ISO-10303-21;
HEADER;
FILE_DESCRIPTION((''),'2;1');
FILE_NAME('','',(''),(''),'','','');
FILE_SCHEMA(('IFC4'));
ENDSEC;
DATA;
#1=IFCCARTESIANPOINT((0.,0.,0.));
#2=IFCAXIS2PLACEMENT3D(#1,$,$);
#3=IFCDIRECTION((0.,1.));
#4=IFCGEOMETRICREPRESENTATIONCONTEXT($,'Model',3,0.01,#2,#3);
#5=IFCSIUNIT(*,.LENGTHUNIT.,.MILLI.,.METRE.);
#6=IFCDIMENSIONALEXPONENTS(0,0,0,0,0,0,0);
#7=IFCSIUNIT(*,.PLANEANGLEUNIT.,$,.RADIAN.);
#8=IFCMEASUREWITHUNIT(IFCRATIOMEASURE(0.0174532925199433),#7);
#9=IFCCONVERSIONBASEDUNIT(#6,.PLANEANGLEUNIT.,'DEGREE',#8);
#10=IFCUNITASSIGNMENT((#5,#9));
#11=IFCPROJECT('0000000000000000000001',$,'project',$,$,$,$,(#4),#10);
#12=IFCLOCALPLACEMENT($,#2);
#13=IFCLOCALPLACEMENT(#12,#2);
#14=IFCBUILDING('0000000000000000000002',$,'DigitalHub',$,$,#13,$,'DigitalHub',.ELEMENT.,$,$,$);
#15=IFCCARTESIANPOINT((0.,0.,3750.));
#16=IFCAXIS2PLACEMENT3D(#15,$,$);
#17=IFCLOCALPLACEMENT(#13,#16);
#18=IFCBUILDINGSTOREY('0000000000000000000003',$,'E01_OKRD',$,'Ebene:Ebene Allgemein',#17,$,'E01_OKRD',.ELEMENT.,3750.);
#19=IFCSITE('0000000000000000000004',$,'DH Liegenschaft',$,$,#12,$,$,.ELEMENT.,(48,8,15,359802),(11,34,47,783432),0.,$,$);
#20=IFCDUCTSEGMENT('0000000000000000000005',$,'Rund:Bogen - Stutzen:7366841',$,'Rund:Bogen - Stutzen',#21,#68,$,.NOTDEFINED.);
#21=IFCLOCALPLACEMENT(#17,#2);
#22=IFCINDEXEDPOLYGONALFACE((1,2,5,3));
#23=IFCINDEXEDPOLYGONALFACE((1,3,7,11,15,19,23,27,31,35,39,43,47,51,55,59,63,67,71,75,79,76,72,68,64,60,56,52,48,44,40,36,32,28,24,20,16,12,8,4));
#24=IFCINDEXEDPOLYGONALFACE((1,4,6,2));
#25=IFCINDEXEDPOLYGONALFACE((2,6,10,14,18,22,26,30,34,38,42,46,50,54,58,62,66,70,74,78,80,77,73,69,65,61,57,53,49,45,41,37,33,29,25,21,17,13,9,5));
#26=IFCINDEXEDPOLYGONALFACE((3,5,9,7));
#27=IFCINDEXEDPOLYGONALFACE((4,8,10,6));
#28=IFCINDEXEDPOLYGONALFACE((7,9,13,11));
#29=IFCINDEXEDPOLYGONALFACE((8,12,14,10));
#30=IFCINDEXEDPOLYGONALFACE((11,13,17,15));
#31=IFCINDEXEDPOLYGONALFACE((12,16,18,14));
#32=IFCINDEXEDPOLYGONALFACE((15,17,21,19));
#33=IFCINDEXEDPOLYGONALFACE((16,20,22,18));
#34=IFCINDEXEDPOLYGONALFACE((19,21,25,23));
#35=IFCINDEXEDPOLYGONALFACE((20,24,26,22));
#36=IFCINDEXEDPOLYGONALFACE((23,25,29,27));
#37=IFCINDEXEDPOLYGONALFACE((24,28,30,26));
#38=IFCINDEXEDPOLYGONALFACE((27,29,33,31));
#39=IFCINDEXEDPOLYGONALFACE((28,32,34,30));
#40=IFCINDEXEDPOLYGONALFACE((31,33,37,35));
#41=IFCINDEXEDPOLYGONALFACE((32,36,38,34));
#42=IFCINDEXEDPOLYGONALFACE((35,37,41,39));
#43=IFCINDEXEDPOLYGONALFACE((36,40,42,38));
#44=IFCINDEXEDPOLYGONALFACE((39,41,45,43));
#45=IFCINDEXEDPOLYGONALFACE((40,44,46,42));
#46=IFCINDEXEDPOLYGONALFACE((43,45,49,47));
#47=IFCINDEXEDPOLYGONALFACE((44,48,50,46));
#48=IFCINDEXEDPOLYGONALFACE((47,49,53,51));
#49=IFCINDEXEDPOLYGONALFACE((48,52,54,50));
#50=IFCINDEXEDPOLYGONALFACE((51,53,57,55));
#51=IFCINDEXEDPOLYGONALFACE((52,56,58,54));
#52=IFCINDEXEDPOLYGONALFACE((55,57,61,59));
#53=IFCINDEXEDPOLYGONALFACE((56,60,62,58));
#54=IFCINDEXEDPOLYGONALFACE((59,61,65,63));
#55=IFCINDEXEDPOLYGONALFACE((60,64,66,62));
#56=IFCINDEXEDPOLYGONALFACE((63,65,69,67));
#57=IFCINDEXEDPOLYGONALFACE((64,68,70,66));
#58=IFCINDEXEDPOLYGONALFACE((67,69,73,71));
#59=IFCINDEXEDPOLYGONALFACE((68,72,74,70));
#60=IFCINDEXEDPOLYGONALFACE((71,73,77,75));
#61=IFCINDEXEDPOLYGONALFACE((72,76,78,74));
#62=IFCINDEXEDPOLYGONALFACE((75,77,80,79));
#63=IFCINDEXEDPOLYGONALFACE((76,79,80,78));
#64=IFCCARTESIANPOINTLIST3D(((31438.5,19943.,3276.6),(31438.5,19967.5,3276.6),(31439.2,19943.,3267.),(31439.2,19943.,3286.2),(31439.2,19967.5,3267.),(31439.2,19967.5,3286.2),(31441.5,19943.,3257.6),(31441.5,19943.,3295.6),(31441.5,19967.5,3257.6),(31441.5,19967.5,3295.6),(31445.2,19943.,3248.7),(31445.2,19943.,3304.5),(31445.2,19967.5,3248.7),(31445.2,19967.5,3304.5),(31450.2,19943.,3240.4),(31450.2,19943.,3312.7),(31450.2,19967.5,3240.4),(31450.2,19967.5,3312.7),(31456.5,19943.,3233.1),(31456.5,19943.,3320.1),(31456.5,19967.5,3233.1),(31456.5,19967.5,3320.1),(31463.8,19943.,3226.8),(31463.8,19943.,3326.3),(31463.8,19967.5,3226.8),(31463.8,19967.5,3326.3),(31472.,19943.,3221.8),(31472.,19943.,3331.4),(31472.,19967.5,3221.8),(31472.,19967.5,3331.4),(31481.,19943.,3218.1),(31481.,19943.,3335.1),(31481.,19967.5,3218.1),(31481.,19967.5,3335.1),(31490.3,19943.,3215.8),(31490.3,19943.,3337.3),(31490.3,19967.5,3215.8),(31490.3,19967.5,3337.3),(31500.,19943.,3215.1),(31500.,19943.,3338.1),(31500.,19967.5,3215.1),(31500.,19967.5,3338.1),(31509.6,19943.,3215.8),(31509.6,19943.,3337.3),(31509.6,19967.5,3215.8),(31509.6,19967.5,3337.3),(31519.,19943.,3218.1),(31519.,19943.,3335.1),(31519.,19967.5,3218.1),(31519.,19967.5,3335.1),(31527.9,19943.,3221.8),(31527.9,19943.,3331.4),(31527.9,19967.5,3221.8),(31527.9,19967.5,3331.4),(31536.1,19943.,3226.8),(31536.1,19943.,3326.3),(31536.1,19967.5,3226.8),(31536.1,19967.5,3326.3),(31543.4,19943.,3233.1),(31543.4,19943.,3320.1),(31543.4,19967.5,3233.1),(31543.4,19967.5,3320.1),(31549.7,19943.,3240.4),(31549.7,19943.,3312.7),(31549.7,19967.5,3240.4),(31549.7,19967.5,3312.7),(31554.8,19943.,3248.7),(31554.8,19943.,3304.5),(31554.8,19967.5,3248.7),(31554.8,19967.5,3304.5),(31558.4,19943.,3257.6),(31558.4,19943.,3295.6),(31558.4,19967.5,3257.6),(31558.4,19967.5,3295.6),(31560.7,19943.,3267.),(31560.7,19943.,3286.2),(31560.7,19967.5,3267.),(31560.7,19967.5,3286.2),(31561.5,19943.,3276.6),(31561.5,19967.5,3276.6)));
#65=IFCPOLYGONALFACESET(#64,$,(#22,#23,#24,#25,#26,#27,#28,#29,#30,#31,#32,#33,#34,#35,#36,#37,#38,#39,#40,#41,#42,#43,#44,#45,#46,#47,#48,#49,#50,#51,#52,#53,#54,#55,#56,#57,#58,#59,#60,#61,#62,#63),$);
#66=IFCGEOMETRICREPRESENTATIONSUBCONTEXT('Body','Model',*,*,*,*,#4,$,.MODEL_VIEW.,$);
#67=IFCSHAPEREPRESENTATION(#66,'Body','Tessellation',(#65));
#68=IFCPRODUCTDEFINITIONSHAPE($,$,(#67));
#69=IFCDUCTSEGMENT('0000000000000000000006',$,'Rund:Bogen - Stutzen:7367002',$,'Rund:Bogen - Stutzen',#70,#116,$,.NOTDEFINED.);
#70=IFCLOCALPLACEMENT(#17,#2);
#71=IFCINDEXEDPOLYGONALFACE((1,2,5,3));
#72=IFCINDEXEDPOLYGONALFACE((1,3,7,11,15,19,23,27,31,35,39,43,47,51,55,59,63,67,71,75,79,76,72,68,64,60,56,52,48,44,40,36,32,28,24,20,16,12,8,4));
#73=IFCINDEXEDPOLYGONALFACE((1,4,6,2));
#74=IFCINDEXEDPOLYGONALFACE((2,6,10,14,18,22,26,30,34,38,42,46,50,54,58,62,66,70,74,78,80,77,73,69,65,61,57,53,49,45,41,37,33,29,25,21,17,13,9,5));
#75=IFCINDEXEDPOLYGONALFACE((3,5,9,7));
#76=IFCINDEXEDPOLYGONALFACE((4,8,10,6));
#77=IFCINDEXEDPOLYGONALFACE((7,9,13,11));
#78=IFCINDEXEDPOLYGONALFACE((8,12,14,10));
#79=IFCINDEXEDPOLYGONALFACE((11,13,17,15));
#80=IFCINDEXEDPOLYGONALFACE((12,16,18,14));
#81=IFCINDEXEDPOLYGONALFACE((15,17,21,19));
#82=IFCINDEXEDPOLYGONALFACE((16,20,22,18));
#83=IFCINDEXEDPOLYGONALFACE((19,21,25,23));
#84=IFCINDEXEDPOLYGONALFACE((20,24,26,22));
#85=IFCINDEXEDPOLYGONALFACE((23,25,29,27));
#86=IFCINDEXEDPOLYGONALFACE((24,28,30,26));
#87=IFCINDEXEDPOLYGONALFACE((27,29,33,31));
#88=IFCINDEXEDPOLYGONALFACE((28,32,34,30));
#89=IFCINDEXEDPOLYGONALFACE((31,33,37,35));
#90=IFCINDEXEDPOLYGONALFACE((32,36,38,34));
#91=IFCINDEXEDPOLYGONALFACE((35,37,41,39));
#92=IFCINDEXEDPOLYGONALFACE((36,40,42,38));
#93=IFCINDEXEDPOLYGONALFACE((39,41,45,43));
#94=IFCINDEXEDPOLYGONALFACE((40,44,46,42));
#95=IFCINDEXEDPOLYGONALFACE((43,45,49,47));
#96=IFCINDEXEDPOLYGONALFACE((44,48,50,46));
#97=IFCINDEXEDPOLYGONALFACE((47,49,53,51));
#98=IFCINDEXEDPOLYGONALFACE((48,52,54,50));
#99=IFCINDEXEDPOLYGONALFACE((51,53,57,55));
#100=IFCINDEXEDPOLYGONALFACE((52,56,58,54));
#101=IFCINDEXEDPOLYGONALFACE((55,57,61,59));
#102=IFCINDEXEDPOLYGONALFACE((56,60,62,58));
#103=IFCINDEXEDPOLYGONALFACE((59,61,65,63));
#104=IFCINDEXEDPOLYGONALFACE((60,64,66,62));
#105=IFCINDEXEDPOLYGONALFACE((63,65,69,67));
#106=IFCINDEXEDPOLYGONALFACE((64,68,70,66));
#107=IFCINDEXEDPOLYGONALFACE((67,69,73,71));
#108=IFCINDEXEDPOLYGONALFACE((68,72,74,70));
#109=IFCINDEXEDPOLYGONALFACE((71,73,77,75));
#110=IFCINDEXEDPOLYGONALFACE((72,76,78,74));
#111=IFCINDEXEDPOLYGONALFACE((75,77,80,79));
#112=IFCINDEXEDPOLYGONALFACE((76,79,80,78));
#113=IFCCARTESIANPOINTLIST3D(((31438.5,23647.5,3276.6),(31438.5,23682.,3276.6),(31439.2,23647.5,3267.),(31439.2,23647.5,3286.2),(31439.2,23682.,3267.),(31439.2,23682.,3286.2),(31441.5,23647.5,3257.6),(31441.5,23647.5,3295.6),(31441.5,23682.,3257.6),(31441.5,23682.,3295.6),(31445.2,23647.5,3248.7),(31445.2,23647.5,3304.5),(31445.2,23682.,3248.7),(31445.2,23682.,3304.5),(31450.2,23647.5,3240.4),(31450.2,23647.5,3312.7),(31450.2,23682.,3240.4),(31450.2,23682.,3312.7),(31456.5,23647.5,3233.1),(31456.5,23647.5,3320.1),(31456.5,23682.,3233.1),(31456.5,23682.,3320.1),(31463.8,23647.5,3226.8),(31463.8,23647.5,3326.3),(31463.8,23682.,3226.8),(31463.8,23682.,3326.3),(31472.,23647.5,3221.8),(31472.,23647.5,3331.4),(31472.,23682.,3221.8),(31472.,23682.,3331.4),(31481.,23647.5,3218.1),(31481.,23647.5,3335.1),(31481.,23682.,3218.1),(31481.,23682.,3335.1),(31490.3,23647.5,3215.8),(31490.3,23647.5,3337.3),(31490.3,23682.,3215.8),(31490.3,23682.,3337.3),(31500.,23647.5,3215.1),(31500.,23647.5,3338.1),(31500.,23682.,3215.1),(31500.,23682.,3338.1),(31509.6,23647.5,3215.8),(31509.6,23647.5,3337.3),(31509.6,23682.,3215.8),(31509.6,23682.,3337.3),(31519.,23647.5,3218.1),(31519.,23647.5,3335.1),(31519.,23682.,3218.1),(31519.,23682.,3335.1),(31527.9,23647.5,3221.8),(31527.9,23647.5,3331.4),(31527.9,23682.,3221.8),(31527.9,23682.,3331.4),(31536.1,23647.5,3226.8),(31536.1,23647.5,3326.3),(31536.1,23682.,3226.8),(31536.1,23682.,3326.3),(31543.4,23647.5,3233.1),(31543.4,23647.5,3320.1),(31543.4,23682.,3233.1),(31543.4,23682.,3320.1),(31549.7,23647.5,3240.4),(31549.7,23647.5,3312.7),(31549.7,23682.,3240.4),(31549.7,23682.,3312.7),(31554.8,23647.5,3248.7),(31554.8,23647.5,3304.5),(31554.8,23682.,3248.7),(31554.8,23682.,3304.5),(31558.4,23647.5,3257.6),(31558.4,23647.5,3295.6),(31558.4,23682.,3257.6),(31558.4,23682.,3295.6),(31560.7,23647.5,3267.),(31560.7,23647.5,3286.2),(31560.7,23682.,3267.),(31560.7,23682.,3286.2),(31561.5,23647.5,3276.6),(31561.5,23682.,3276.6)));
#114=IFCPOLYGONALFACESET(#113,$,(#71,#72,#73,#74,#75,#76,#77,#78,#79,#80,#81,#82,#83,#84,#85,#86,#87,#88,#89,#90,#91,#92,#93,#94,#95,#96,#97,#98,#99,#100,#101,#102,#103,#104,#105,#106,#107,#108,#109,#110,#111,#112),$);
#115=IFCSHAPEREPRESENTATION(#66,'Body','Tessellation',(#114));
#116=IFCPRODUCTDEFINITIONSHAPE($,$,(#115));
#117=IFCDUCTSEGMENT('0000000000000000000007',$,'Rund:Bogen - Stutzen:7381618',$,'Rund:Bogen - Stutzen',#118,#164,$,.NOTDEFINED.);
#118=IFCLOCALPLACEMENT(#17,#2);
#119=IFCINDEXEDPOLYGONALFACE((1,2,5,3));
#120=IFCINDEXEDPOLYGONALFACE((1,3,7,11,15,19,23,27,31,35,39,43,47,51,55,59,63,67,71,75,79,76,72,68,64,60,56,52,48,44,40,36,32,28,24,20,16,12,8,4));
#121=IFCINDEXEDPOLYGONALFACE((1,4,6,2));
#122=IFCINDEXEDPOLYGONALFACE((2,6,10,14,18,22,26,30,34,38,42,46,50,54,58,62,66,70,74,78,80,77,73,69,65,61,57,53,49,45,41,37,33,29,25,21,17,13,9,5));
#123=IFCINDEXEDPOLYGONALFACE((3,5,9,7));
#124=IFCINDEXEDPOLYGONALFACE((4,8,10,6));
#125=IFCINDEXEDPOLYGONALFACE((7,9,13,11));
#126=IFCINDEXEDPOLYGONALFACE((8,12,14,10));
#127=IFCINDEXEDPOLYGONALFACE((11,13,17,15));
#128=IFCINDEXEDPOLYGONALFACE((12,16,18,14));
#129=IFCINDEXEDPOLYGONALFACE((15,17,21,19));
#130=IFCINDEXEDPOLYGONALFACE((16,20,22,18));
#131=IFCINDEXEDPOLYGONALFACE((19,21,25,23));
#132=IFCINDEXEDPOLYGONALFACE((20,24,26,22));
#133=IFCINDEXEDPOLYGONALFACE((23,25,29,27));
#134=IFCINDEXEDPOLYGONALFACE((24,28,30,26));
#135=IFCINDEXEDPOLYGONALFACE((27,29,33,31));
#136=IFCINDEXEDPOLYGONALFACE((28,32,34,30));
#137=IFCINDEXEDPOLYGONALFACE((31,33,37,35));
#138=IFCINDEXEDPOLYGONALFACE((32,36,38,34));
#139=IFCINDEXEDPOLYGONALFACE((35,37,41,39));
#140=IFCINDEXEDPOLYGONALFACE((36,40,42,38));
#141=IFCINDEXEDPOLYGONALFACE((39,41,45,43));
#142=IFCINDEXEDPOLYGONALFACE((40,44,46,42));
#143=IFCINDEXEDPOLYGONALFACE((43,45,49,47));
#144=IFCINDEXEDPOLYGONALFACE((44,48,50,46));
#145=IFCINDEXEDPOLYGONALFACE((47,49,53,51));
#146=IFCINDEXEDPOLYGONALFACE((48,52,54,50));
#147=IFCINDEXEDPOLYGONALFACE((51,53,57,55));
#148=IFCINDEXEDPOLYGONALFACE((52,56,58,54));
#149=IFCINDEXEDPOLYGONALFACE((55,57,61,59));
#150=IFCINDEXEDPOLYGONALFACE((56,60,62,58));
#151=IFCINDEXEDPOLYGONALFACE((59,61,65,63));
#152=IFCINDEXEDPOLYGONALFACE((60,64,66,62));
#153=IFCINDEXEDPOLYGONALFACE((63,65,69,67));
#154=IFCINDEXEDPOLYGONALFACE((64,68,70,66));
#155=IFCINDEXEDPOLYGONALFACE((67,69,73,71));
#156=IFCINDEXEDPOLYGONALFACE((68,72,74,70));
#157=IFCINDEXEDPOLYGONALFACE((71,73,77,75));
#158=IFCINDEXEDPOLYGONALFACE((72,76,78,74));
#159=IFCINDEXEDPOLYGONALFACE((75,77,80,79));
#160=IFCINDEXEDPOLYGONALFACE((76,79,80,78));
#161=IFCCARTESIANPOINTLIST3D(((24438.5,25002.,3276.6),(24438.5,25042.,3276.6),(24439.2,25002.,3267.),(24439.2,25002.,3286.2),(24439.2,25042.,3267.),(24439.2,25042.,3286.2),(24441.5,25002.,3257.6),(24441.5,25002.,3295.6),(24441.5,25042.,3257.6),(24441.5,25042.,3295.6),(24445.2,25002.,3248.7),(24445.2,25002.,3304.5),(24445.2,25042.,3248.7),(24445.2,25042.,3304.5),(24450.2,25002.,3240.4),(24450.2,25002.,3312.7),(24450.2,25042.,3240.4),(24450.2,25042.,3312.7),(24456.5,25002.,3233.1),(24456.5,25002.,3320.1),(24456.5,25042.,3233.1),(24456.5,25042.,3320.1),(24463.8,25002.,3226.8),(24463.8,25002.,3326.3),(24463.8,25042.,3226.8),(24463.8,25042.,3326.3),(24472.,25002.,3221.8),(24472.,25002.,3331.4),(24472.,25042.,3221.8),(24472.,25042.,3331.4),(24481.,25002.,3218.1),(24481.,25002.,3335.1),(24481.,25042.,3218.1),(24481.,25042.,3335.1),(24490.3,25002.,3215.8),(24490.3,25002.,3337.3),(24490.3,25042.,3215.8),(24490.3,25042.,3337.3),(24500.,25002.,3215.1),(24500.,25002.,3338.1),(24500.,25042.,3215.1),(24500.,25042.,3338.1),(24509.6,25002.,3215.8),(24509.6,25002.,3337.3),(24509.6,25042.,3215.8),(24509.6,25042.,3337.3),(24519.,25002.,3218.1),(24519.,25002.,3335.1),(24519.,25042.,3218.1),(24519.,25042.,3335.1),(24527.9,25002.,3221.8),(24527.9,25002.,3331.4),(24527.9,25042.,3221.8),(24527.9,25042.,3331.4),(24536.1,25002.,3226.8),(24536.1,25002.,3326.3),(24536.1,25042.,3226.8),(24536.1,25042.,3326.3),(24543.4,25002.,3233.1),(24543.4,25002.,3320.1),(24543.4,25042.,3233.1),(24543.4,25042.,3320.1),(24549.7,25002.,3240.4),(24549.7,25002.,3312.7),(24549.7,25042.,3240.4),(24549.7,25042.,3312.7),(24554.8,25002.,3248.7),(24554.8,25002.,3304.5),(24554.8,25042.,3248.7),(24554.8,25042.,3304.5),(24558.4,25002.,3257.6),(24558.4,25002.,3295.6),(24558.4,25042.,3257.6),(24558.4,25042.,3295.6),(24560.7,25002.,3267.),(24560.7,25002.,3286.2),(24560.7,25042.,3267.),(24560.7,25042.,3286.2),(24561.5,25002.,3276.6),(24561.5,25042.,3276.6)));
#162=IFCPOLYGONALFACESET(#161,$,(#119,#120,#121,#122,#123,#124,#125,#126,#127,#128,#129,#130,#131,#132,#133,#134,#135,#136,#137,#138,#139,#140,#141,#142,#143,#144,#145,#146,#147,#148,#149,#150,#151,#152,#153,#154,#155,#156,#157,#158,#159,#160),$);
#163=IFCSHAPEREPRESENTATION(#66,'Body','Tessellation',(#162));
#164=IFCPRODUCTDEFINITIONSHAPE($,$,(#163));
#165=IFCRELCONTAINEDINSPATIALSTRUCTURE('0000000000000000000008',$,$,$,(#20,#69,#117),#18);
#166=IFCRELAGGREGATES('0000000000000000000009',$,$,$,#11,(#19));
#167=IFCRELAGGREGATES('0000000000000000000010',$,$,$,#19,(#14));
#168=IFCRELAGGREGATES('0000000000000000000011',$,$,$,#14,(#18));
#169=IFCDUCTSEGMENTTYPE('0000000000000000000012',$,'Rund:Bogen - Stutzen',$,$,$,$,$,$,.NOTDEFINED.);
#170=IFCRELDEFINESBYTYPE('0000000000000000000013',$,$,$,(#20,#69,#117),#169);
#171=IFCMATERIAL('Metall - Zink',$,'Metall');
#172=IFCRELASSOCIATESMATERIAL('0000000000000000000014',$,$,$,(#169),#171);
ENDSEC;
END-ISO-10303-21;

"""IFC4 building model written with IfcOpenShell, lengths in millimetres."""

from ifc_helpers import new_model, entity, si_unit, converted_unit, direction, frame, origin, place, context, subcontext, project, spatial, indexed_curve, outline, extrude, material, type_object, element, save


model = new_model("IFC4")

# Units and contexts
model_context = context("Model", 3, precision=0.01, world=origin(), true_north=direction((0.0, 1.0)))
body_context = subcontext(model_context, "Body", "Model", "MODEL_VIEW")
ifc_project = project(units=[si_unit("LENGTHUNIT", "METRE", prefix="MILLI"), converted_unit("PLANEANGLEUNIT", "DEGREE", entity("IfcRatioMeasure", 0.0174532925199433), si_unit("PLANEANGLEUNIT", "RADIAN"), dimensions=[0, 0, 0, 0, 0, 0, 0])], contexts=[model_context])

# Site, building, storey
site_placement = place(None, origin())
site = spatial("IfcSite", under=ifc_project, at=site_placement, Name="DH Liegenschaft", CompositionType="ELEMENT", RefLatitude=(48, 8, 15, 359802), RefLongitude=(11, 34, 47, 783432), RefElevation=0.0)
building_placement = place(site_placement, origin())
building = spatial("IfcBuilding", under=site, at=building_placement, Name="DigitalHub", LongName="DigitalHub", CompositionType="ELEMENT")
storey_placement = place(building_placement, frame((0.0, 0.0, 3750.0)))
storey = spatial("IfcBuildingStorey", under=building, at=storey_placement, Name="E01_OKRD", ObjectType="Ebene:Ebene Allgemein", LongName="E01_OKRD", CompositionType="ELEMENT", Elevation=3750.0)

# Shared definitions
ifc_material_1 = material(Name="Metall - Zink", Category="Metall")

# Duct segments
duct_segment_type_1 = type_object("IfcDuctSegmentType", Name="Rund:Bogen - Stutzen", PredefinedType="NOTDEFINED", material=ifc_material_1)
duct_segment_1_placement = place(storey_placement, frame((31436.9, 19943.0, 3213.5)))
element("IfcDuctSegment", 1, at=duct_segment_1_placement, inside=storey, type_object=duct_segment_type_1, Name="Rund:Bogen - Stutzen:7366841", ObjectType="Rund:Bogen - Stutzen", PredefinedType="NOTDEFINED", context=body_context, shape_type="SweptSolid", body=[
    extrude(outline(indexed_curve([(61.5, 0.0), (60.7, 9.6), (58.5, 19.0), (54.8, 27.9), (49.8, 36.1), (43.5, 43.5), (36.1, 49.8), (27.9, 54.8), (19.0, 58.5), (9.6, 60.7), (0.0, 61.5), (-9.6, 60.7), (-19.0, 58.5), (-27.9, 54.8), (-36.1, 49.8), (-43.5, 43.5), (-49.8, 36.1), (-54.8, 27.9), (-58.5, 19.0), (-60.7, 9.6), (-61.5, 0.0), (-60.7, -9.6), (-58.5, -19.0), (-54.8, -27.9), (-49.8, -36.1), (-43.5, -43.5), (-36.1, -49.8), (-27.9, -54.8), (-19.0, -58.5), (-9.6, -60.7), (0.0, -61.5), (9.6, -60.7), (19.0, -58.5), (27.9, -54.8), (36.1, -49.8), (43.5, -43.5), (49.8, -36.1), (54.8, -27.9), (58.5, -19.0), (60.7, -9.6), (61.5, 0.0)], self_intersect=False)), frame((63.1, 0.0, 63.1), z_axis=(0.0, 1.0, 0.0), x_axis=(-1.0, 0.0, 0.0)), (0.0, 0.0, 1.0), 24.5),
])
duct_segment_2_placement = place(storey_placement, frame((31436.9, 23647.5, 3213.5)))
element("IfcDuctSegment", 2, at=duct_segment_2_placement, inside=storey, type_object=duct_segment_type_1, Name="Rund:Bogen - Stutzen:7367002", ObjectType="Rund:Bogen - Stutzen", PredefinedType="NOTDEFINED", context=body_context, shape_type="SweptSolid", body=[
    extrude(outline(indexed_curve([(61.5, 0.0), (60.7, 9.6), (58.5, 19.0), (54.8, 27.9), (49.8, 36.1), (43.5, 43.5), (36.1, 49.8), (27.9, 54.8), (19.0, 58.5), (9.6, 60.7), (0.0, 61.5), (-9.6, 60.7), (-19.0, 58.5), (-27.9, 54.8), (-36.1, 49.8), (-43.5, 43.5), (-49.8, 36.1), (-54.8, 27.9), (-58.5, 19.0), (-60.7, 9.6), (-61.5, 0.0), (-60.7, -9.6), (-58.5, -19.0), (-54.8, -27.9), (-49.8, -36.1), (-43.5, -43.5), (-36.1, -49.8), (-27.9, -54.8), (-19.0, -58.5), (-9.6, -60.7), (0.0, -61.5), (9.6, -60.7), (19.0, -58.5), (27.9, -54.8), (36.1, -49.8), (43.5, -43.5), (49.8, -36.1), (54.8, -27.9), (58.5, -19.0), (60.7, -9.6), (61.5, 0.0)], self_intersect=False)), frame((63.1, 0.0, 63.1), z_axis=(0.0, 1.0, 0.0), x_axis=(1.0, 0.0, 0.0)), (0.0, 0.0, 1.0), 34.5),
])
duct_segment_3_placement = place(storey_placement, frame((24436.9, 25002.0, 3213.5)))
element("IfcDuctSegment", 3, at=duct_segment_3_placement, inside=storey, type_object=duct_segment_type_1, Name="Rund:Bogen - Stutzen:7381618", ObjectType="Rund:Bogen - Stutzen", PredefinedType="NOTDEFINED", context=body_context, shape_type="SweptSolid", body=[
    extrude(outline(indexed_curve([(61.5, 0.0), (60.7, 9.6), (58.5, 19.0), (54.8, 27.9), (49.8, 36.1), (43.5, 43.5), (36.1, 49.8), (27.9, 54.8), (19.0, 58.5), (9.6, 60.7), (0.0, 61.5), (-9.6, 60.7), (-19.0, 58.5), (-27.9, 54.8), (-36.1, 49.8), (-43.5, 43.5), (-49.8, 36.1), (-54.8, 27.9), (-58.5, 19.0), (-60.7, 9.6), (-61.5, 0.0), (-60.7, -9.6), (-58.5, -19.0), (-54.8, -27.9), (-49.8, -36.1), (-43.5, -43.5), (-36.1, -49.8), (-27.9, -54.8), (-19.0, -58.5), (-9.6, -60.7), (0.0, -61.5), (9.6, -60.7), (19.0, -58.5), (27.9, -54.8), (36.1, -49.8), (43.5, -43.5), (49.8, -36.1), (54.8, -27.9), (58.5, -19.0), (60.7, -9.6), (61.5, 0.0)], self_intersect=False)), frame((63.1, 0.0, 63.1), z_axis=(0.0, 1.0, 0.0), x_axis=(-1.0, 0.0, 0.0)), (0.0, 0.0, 1.0), 40.0),
])

save(model, "model.ifc")
